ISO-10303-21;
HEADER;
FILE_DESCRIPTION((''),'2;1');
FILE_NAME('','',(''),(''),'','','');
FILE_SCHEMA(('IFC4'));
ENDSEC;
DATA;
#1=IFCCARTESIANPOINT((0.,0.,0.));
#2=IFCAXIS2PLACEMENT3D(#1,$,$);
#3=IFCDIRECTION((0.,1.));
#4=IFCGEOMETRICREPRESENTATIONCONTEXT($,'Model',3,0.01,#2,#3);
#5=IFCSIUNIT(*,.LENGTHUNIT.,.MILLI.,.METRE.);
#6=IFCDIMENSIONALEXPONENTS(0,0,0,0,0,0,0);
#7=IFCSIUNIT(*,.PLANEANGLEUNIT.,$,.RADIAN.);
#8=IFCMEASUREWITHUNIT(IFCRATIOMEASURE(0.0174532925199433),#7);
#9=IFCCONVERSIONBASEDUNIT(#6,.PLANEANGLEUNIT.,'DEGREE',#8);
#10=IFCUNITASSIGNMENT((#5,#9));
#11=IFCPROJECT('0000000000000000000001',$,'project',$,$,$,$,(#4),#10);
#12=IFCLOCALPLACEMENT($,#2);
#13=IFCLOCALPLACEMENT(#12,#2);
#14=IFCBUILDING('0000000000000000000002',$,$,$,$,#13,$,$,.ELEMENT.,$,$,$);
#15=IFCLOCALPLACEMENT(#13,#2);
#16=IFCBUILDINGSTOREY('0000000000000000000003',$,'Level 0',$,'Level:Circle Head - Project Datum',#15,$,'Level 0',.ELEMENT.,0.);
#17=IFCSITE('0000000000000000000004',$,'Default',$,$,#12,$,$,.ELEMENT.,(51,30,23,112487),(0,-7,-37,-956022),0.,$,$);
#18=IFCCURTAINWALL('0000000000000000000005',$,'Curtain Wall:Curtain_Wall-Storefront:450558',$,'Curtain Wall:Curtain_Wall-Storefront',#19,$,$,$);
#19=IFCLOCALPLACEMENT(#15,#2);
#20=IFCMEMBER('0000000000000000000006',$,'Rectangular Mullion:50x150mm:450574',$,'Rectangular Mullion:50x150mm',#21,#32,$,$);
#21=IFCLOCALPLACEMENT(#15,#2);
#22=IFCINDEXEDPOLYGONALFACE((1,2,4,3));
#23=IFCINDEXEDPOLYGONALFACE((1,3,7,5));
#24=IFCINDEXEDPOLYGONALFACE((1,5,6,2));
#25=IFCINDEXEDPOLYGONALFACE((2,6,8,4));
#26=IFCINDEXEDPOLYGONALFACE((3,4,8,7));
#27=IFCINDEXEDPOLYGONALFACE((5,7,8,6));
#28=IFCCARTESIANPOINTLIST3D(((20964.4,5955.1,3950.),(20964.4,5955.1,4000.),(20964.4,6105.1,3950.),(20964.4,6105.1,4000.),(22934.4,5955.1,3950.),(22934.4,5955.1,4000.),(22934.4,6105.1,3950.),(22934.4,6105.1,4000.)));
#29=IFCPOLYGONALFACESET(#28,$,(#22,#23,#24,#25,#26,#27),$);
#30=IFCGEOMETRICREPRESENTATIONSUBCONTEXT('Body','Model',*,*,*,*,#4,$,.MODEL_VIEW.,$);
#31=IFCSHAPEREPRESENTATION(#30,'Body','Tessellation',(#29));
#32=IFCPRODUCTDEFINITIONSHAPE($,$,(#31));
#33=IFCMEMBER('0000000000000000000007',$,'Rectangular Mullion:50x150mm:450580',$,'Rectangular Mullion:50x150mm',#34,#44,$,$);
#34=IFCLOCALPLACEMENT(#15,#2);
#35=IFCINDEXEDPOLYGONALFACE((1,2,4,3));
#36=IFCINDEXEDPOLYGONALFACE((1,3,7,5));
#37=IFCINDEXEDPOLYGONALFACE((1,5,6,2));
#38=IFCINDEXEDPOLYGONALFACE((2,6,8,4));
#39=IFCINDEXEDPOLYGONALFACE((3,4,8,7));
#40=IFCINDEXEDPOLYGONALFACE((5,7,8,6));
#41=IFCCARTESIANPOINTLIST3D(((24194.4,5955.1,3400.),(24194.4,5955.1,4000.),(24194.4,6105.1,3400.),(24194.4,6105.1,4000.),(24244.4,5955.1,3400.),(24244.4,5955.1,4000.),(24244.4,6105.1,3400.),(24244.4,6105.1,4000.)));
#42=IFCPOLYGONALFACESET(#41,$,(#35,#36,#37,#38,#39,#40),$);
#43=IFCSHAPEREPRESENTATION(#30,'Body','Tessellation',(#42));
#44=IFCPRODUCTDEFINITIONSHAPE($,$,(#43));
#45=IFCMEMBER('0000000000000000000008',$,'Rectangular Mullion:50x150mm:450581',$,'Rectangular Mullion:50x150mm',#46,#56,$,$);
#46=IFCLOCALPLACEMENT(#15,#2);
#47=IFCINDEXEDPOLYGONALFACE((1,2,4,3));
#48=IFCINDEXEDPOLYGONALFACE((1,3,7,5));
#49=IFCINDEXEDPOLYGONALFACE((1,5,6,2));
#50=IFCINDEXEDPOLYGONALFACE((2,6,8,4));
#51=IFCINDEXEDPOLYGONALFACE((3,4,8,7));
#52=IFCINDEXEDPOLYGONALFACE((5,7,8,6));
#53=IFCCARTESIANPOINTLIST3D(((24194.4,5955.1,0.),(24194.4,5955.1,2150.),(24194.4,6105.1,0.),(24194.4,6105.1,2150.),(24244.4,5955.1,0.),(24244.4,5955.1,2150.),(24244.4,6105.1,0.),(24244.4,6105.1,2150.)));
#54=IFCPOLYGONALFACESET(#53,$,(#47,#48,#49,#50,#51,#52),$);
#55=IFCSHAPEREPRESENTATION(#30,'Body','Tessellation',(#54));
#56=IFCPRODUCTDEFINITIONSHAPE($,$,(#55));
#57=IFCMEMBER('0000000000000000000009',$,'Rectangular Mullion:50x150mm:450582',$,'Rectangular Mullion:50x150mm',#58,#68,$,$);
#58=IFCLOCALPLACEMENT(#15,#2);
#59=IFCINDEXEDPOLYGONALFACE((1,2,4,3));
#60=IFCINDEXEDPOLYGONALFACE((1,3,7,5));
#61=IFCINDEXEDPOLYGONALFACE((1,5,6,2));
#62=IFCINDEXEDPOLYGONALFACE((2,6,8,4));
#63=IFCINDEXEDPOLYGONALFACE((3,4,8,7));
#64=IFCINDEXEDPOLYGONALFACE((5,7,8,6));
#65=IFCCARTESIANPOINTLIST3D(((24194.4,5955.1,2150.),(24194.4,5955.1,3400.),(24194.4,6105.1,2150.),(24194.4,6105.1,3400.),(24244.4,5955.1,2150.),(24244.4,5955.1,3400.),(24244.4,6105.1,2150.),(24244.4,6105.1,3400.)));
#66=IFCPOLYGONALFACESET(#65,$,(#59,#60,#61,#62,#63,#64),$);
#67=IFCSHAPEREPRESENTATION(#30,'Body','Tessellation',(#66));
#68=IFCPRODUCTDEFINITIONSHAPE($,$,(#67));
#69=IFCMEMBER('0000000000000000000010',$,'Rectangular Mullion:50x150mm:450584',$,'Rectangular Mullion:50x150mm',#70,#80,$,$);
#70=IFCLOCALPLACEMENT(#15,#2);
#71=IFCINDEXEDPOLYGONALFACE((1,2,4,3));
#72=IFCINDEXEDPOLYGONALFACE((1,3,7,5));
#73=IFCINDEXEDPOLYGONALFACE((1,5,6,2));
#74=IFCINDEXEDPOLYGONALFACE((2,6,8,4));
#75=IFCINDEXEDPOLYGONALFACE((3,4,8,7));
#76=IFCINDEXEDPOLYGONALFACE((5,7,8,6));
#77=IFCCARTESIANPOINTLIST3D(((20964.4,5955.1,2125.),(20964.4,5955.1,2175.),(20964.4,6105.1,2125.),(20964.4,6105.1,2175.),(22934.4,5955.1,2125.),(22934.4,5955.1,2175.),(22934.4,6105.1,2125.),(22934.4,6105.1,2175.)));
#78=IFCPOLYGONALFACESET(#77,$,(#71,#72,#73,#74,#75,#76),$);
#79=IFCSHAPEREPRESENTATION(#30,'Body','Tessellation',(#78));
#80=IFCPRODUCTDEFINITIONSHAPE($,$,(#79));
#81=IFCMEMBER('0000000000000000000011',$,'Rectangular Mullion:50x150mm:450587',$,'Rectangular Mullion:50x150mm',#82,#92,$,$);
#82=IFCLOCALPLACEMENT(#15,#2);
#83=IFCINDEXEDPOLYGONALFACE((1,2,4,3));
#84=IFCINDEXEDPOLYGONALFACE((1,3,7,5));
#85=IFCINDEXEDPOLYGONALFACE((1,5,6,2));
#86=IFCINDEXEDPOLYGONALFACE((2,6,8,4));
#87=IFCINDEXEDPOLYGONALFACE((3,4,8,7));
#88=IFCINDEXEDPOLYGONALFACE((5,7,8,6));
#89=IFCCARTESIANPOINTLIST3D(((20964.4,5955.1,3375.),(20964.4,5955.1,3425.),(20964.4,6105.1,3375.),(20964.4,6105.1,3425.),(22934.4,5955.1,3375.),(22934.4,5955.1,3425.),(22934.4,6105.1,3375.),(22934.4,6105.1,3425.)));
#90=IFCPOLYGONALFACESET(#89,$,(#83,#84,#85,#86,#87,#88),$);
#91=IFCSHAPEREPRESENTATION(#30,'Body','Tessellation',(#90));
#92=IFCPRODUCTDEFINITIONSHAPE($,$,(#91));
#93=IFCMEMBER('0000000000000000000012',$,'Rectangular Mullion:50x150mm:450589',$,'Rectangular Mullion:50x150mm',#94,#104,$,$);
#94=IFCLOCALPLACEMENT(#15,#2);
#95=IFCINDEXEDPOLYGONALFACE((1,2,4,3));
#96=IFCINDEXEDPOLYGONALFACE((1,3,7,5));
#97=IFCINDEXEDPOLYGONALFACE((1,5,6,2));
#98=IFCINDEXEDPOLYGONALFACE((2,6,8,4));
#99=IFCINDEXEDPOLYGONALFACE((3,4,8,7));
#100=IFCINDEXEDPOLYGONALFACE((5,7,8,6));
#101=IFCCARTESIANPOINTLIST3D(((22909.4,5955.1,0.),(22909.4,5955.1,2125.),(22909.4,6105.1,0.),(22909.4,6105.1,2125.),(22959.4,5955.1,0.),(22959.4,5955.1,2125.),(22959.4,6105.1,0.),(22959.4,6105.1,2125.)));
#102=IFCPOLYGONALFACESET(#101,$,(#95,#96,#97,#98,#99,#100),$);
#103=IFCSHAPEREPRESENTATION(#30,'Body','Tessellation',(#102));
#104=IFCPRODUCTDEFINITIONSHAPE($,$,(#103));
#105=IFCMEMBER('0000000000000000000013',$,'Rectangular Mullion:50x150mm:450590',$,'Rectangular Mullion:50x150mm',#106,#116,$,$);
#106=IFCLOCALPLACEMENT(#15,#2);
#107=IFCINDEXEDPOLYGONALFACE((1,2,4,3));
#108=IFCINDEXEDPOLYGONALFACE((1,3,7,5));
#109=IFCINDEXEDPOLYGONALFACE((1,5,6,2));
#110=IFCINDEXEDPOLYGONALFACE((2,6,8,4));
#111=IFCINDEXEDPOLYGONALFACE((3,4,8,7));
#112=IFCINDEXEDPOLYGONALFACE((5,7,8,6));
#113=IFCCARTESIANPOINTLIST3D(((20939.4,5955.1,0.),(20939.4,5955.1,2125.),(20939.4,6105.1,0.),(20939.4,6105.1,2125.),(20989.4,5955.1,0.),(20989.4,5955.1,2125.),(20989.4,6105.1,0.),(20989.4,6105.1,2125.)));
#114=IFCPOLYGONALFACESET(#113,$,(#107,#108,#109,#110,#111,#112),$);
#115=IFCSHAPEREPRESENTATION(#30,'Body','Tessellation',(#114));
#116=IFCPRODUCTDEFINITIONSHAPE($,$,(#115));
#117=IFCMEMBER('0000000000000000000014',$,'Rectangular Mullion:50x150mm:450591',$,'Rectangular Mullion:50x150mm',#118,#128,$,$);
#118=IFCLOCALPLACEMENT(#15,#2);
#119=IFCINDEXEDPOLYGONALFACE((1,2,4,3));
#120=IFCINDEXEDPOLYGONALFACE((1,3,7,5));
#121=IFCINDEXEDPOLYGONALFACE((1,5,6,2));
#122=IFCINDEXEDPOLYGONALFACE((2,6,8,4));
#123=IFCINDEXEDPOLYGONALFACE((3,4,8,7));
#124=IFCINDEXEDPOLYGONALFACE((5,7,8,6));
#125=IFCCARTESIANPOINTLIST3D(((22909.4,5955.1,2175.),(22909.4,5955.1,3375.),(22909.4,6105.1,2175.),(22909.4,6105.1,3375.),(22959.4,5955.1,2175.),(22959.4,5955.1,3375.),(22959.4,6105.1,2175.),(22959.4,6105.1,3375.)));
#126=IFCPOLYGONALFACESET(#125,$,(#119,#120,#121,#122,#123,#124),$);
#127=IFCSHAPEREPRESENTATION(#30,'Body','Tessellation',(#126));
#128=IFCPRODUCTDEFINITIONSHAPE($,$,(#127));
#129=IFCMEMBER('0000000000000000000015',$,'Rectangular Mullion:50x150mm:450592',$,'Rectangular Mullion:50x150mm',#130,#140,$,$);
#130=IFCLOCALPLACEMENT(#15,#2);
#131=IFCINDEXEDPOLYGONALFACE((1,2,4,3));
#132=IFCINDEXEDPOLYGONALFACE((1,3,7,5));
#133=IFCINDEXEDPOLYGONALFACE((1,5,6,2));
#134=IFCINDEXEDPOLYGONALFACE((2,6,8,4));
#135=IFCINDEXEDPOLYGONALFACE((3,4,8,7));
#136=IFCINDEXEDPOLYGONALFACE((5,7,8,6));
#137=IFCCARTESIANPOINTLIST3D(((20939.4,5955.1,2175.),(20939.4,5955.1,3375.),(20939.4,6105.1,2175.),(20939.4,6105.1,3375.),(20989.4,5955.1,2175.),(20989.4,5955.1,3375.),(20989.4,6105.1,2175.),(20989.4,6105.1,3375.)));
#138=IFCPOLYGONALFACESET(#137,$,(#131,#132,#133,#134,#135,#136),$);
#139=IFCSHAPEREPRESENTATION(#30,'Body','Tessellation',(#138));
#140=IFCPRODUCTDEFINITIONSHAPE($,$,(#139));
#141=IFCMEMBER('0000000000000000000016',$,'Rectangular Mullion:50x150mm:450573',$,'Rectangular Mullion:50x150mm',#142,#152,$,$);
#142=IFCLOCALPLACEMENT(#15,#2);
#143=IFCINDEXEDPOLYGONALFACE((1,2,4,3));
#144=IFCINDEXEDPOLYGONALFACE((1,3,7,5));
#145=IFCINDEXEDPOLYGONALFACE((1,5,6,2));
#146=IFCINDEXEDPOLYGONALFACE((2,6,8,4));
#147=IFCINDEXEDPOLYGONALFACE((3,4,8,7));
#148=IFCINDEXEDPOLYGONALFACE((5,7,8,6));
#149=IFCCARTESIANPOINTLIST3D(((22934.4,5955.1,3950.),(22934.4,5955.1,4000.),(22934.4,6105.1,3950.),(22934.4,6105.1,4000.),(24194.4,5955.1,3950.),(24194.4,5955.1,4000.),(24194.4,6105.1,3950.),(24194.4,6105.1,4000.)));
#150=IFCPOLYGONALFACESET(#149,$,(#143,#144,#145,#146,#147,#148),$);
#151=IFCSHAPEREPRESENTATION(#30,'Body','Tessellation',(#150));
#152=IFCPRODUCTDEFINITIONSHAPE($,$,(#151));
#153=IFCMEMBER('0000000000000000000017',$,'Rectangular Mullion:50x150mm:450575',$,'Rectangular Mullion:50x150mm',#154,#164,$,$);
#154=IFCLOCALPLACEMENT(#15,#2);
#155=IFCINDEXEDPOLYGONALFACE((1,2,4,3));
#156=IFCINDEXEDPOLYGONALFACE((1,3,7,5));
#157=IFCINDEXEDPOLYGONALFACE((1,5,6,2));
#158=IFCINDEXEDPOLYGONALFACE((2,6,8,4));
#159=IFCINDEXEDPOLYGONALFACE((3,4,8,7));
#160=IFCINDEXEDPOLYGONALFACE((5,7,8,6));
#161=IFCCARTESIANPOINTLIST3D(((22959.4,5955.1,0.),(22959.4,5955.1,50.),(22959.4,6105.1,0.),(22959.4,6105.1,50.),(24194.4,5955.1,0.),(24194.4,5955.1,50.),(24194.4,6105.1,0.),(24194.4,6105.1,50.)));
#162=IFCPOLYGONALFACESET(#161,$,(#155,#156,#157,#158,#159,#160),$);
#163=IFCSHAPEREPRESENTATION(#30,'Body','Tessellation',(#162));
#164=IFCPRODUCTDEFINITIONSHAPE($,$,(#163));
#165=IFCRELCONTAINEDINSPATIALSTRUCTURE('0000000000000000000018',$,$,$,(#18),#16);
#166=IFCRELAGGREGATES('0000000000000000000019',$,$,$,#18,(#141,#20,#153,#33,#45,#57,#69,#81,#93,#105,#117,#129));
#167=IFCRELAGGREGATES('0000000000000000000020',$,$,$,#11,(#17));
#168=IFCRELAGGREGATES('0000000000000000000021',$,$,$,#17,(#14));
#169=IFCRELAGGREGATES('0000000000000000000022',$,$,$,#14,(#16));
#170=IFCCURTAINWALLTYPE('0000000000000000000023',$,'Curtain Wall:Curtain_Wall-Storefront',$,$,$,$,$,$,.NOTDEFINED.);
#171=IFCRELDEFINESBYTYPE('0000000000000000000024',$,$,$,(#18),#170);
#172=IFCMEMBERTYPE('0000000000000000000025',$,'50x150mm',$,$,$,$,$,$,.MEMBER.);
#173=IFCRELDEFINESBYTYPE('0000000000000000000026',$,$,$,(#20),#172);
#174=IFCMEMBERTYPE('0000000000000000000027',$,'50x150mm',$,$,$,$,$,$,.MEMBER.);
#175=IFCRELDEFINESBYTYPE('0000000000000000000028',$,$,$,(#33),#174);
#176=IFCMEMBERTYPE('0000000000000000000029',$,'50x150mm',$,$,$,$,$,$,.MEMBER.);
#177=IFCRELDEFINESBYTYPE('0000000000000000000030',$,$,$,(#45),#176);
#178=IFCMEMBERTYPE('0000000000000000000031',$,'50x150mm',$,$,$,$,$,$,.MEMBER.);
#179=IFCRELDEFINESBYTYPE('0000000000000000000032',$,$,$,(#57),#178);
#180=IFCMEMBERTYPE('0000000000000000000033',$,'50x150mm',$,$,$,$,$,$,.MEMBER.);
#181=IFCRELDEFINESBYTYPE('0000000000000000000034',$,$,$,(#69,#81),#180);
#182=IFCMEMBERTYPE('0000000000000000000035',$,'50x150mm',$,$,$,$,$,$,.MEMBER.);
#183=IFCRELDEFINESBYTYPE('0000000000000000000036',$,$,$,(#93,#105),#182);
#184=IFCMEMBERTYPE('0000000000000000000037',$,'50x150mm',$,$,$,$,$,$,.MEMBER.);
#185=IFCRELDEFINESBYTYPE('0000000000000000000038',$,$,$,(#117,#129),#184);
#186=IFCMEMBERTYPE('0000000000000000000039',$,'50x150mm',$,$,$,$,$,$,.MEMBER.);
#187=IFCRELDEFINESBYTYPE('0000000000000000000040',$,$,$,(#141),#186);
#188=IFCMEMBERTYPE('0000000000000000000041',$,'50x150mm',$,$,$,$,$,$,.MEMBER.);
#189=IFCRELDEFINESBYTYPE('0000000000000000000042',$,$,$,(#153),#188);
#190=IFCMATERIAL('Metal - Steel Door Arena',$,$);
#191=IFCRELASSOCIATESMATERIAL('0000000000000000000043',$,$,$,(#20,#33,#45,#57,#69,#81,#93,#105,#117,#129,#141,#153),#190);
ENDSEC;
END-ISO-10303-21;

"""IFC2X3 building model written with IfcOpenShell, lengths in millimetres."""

from ifc_helpers import new_model, entity, si_unit, converted_unit, direction, frame, origin, origin_2d_with_axis, place, context, subcontext, project, spatial, rectangle, extrude, source, transform, mapped, material, type_object, type_shapes, element, aggregate, save


model = new_model("IFC2X3")

# Units and contexts
model_context = context("Model", 3, precision=0.01, world=origin(), true_north=direction((0.0, 1.0)))
body_context = subcontext(model_context, "Body", "Model", "MODEL_VIEW")
ifc_project = project(units=[si_unit("LENGTHUNIT", "METRE", prefix="MILLI"), converted_unit("PLANEANGLEUNIT", "DEGREE", entity("IfcRatioMeasure", 0.0174532925199433), si_unit("PLANEANGLEUNIT", "RADIAN"), dimensions=[0, 0, 0, 0, 0, 0, 0])], contexts=[model_context])

# Site, building, storey
site_placement = place(None, origin())
site = spatial("IfcSite", under=ifc_project, at=site_placement, Name="Default", CompositionType="ELEMENT", RefLatitude=(51, 30, 23, 112487), RefLongitude=(0, -7, -37, -956022), RefElevation=0.0)
building_placement = place(site_placement, origin())
building = spatial("IfcBuilding", under=site, at=building_placement, CompositionType="ELEMENT")
storey_placement = place(building_placement, origin())
storey = spatial("IfcBuildingStorey", under=building, at=storey_placement, Name="Level 0", ObjectType="Level:Circle Head - Project Datum", LongName="Level 0", CompositionType="ELEMENT", Elevation=0.0)

# Curtain wall, members
curtain_wall_type = type_object("IfcCurtainWallType", Name="Curtain Wall:Curtain_Wall-Storefront", PredefinedType="NOTDEFINED")
curtain_wall_placement = place(storey_placement, origin())
curtain_wall = element("IfcCurtainWall", 1, at=curtain_wall_placement, inside=storey, type_object=curtain_wall_type, Name="Curtain Wall:Curtain_Wall-Storefront:450558", ObjectType="Curtain Wall:Curtain_Wall-Storefront")
ifc_material_1 = material(Name="Metal - Steel Door Arena")
member_type_1 = type_object("IfcMemberType", Name="50x150mm", PredefinedType="MEMBER")
shared_shape_1 = source(origin(), body_context, "Body", "SweptSolid", [
    extrude(rectangle(XDim=150.0, YDim=50.0, at=origin_2d_with_axis()), frame((-25.0, 0.0, -1970.0), z_axis=(0.0, 0.0, 1.0), x_axis=(0.0, -1.0, 0.0)), (0.0, 0.0, 1.0), 1970.0),
])
type_shapes(member_type_1, [shared_shape_1])
member_1_placement = place(storey_placement, frame((20964.4, 6030.1, 4000.0), z_axis=(-1.0, 0.0, 0.0), x_axis=(0.0, 0.0, 1.0)))
member_1 = element("IfcMember", 2, at=member_1_placement, type_object=member_type_1, material=ifc_material_1, Name="Rectangular Mullion:50x150mm:450574", ObjectType="Rectangular Mullion:50x150mm", context=body_context, shape_type="MappedRepresentation", body=[
    mapped(shared_shape_1, transform((0.0, 0.0, 0.0), scale=1.0)),
])
member_type_2 = type_object("IfcMemberType", Name="50x150mm", PredefinedType="MEMBER")
shared_shape_2 = source(origin(), body_context, "Body", "SweptSolid", [
    extrude(rectangle(XDim=150.0, YDim=50.0, at=origin_2d_with_axis()), frame((-25.0, 0.0, -600.0), z_axis=(0.0, 0.0, 1.0), x_axis=(0.0, -1.0, 0.0)), (0.0, 0.0, 1.0), 600.0),
])
type_shapes(member_type_2, [shared_shape_2])
member_2_placement = place(storey_placement, frame((24244.4, 6030.1, 4000.0)))
member_2 = element("IfcMember", 3, at=member_2_placement, type_object=member_type_2, material=ifc_material_1, Name="Rectangular Mullion:50x150mm:450580", ObjectType="Rectangular Mullion:50x150mm", context=body_context, shape_type="MappedRepresentation", body=[
    mapped(shared_shape_2, transform((0.0, 0.0, 0.0), scale=1.0)),
])
member_type_3 = type_object("IfcMemberType", Name="50x150mm", PredefinedType="MEMBER")
shared_shape_3 = source(origin(), body_context, "Body", "SweptSolid", [
    extrude(rectangle(XDim=150.0, YDim=50.0, at=origin_2d_with_axis()), frame((-25.0, 0.0, -2150.0), z_axis=(0.0, 0.0, 1.0), x_axis=(0.0, -1.0, 0.0)), (0.0, 0.0, 1.0), 2150.0),
])
type_shapes(member_type_3, [shared_shape_3])
member_3_placement = place(storey_placement, frame((24244.4, 6030.1, 2150.0)))
member_3 = element("IfcMember", 4, at=member_3_placement, type_object=member_type_3, material=ifc_material_1, Name="Rectangular Mullion:50x150mm:450581", ObjectType="Rectangular Mullion:50x150mm", context=body_context, shape_type="MappedRepresentation", body=[
    mapped(shared_shape_3, transform((0.0, 0.0, 0.0), scale=1.0)),
])
member_type_4 = type_object("IfcMemberType", Name="50x150mm", PredefinedType="MEMBER")
shared_shape_4 = source(origin(), body_context, "Body", "SweptSolid", [
    extrude(rectangle(XDim=150.0, YDim=50.0, at=origin_2d_with_axis()), frame((-25.0, 0.0, -1250.0), z_axis=(0.0, 0.0, 1.0), x_axis=(0.0, -1.0, 0.0)), (0.0, 0.0, 1.0), 1250.0),
])
type_shapes(member_type_4, [shared_shape_4])
member_4_placement = place(storey_placement, frame((24244.4, 6030.1, 3400.0)))
member_4 = element("IfcMember", 5, at=member_4_placement, type_object=member_type_4, material=ifc_material_1, Name="Rectangular Mullion:50x150mm:450582", ObjectType="Rectangular Mullion:50x150mm", context=body_context, shape_type="MappedRepresentation", body=[
    mapped(shared_shape_4, transform((0.0, 0.0, 0.0), scale=1.0)),
])
member_type_5 = type_object("IfcMemberType", Name="50x150mm", PredefinedType="MEMBER")
shared_shape_5 = source(origin(), body_context, "Body", "SweptSolid", [
    extrude(rectangle(XDim=150.0, YDim=50.0, at=origin_2d_with_axis()), frame((0.0, 0.0, -1970.0), z_axis=(0.0, 0.0, 1.0), x_axis=(0.0, -1.0, 0.0)), (0.0, 0.0, 1.0), 1970.0),
])
type_shapes(member_type_5, [shared_shape_5])
member_5_placement = place(storey_placement, frame((20964.4, 6030.1, 2150.0), z_axis=(-1.0, 0.0, 0.0), x_axis=(0.0, 0.0, 1.0)))
member_5 = element("IfcMember", 6, at=member_5_placement, type_object=member_type_5, material=ifc_material_1, Name="Rectangular Mullion:50x150mm:450584", ObjectType="Rectangular Mullion:50x150mm", context=body_context, shape_type="MappedRepresentation", body=[
    mapped(shared_shape_5, transform((0.0, 0.0, 0.0), scale=1.0)),
])
member_6_placement = place(storey_placement, frame((20964.4, 6030.1, 3400.0), z_axis=(-1.0, 0.0, 0.0), x_axis=(0.0, 0.0, 1.0)))
member_6 = element("IfcMember", 7, at=member_6_placement, type_object=member_type_5, material=ifc_material_1, Name="Rectangular Mullion:50x150mm:450587", ObjectType="Rectangular Mullion:50x150mm", context=body_context, shape_type="MappedRepresentation", body=[
    mapped(shared_shape_5, transform((0.0, 0.0, 0.0), scale=1.0)),
])
member_type_6 = type_object("IfcMemberType", Name="50x150mm", PredefinedType="MEMBER")
shared_shape_6 = source(origin(), body_context, "Body", "SweptSolid", [
    extrude(rectangle(XDim=150.0, YDim=50.0, at=origin_2d_with_axis()), frame((0.0, 0.0, -2125.0), z_axis=(0.0, 0.0, 1.0), x_axis=(0.0, -1.0, 0.0)), (0.0, 0.0, 1.0), 2125.0),
])
type_shapes(member_type_6, [shared_shape_6])
member_7_placement = place(storey_placement, frame((22934.4, 6030.1, 0.0), z_axis=(0.0, 0.0, -1.0), x_axis=(-1.0, 0.0, 0.0)))
member_7 = element("IfcMember", 8, at=member_7_placement, type_object=member_type_6, material=ifc_material_1, Name="Rectangular Mullion:50x150mm:450589", ObjectType="Rectangular Mullion:50x150mm", context=body_context, shape_type="MappedRepresentation", body=[
    mapped(shared_shape_6, transform((0.0, 0.0, 0.0), scale=1.0)),
])
member_8_placement = place(storey_placement, frame((20964.4, 6030.1, 0.0), z_axis=(0.0, 0.0, -1.0), x_axis=(-1.0, 0.0, 0.0)))
member_8 = element("IfcMember", 9, at=member_8_placement, type_object=member_type_6, material=ifc_material_1, Name="Rectangular Mullion:50x150mm:450590", ObjectType="Rectangular Mullion:50x150mm", context=body_context, shape_type="MappedRepresentation", body=[
    mapped(shared_shape_6, transform((0.0, 0.0, 0.0), scale=1.0)),
])
member_type_7 = type_object("IfcMemberType", Name="50x150mm", PredefinedType="MEMBER")
shared_shape_7 = source(origin(), body_context, "Body", "SweptSolid", [
    extrude(rectangle(XDim=150.0, YDim=50.0, at=origin_2d_with_axis()), frame((0.0, 0.0, -1200.0), z_axis=(0.0, 0.0, 1.0), x_axis=(0.0, -1.0, 0.0)), (0.0, 0.0, 1.0), 1200.0),
])
type_shapes(member_type_7, [shared_shape_7])
member_9_placement = place(storey_placement, frame((22934.4, 6030.1, 2175.0), z_axis=(0.0, 0.0, -1.0), x_axis=(-1.0, 0.0, 0.0)))
member_9 = element("IfcMember", 10, at=member_9_placement, type_object=member_type_7, material=ifc_material_1, Name="Rectangular Mullion:50x150mm:450591", ObjectType="Rectangular Mullion:50x150mm", context=body_context, shape_type="MappedRepresentation", body=[
    mapped(shared_shape_7, transform((0.0, 0.0, 0.0), scale=1.0)),
])
member_10_placement = place(storey_placement, frame((20964.4, 6030.1, 2175.0), z_axis=(0.0, 0.0, -1.0), x_axis=(-1.0, 0.0, 0.0)))
member_10 = element("IfcMember", 11, at=member_10_placement, type_object=member_type_7, material=ifc_material_1, Name="Rectangular Mullion:50x150mm:450592", ObjectType="Rectangular Mullion:50x150mm", context=body_context, shape_type="MappedRepresentation", body=[
    mapped(shared_shape_7, transform((0.0, 0.0, 0.0), scale=1.0)),
])
member_type_8 = type_object("IfcMemberType", Name="50x150mm", PredefinedType="MEMBER")
shared_shape_8 = source(origin(), body_context, "Body", "SweptSolid", [
    extrude(rectangle(XDim=150.0, YDim=50.0, at=origin_2d_with_axis()), frame((-25.0, 0.0, -1260.0), z_axis=(0.0, 0.0, 1.0), x_axis=(0.0, -1.0, 0.0)), (0.0, 0.0, 1.0), 1260.0),
])
type_shapes(member_type_8, [shared_shape_8])
member_11_placement = place(storey_placement, frame((22934.4, 6030.1, 4000.0), z_axis=(-1.0, 0.0, 0.0), x_axis=(0.0, 0.0, 1.0)))
member_11 = element("IfcMember", 12, at=member_11_placement, type_object=member_type_8, material=ifc_material_1, Name="Rectangular Mullion:50x150mm:450573", ObjectType="Rectangular Mullion:50x150mm", context=body_context, shape_type="MappedRepresentation", body=[
    mapped(shared_shape_8, transform((0.0, 0.0, 0.0), scale=1.0)),
])
member_type_9 = type_object("IfcMemberType", Name="50x150mm", PredefinedType="MEMBER")
shared_shape_9 = source(origin(), body_context, "Body", "SweptSolid", [
    extrude(rectangle(XDim=150.0, YDim=50.0, at=origin_2d_with_axis()), frame((-25.0, 0.0, -1235.0), z_axis=(0.0, 0.0, 1.0), x_axis=(0.0, -1.0, 0.0)), (0.0, 0.0, 1.0), 1235.0),
])
type_shapes(member_type_9, [shared_shape_9])
member_12_placement = place(storey_placement, frame((24194.4, 6030.1, 0.0), z_axis=(1.0, 0.0, 0.0), x_axis=(0.0, 0.0, -1.0)))
member_12 = element("IfcMember", 13, at=member_12_placement, type_object=member_type_9, material=ifc_material_1, Name="Rectangular Mullion:50x150mm:450575", ObjectType="Rectangular Mullion:50x150mm", context=body_context, shape_type="MappedRepresentation", body=[
    mapped(shared_shape_9, transform((0.0, 0.0, 0.0), scale=1.0)),
])
aggregate(curtain_wall, [member_11, member_1, member_12, member_2, member_3, member_4, member_5, member_6, member_7, member_8, member_9, member_10])

save(model, "model.ifc")
